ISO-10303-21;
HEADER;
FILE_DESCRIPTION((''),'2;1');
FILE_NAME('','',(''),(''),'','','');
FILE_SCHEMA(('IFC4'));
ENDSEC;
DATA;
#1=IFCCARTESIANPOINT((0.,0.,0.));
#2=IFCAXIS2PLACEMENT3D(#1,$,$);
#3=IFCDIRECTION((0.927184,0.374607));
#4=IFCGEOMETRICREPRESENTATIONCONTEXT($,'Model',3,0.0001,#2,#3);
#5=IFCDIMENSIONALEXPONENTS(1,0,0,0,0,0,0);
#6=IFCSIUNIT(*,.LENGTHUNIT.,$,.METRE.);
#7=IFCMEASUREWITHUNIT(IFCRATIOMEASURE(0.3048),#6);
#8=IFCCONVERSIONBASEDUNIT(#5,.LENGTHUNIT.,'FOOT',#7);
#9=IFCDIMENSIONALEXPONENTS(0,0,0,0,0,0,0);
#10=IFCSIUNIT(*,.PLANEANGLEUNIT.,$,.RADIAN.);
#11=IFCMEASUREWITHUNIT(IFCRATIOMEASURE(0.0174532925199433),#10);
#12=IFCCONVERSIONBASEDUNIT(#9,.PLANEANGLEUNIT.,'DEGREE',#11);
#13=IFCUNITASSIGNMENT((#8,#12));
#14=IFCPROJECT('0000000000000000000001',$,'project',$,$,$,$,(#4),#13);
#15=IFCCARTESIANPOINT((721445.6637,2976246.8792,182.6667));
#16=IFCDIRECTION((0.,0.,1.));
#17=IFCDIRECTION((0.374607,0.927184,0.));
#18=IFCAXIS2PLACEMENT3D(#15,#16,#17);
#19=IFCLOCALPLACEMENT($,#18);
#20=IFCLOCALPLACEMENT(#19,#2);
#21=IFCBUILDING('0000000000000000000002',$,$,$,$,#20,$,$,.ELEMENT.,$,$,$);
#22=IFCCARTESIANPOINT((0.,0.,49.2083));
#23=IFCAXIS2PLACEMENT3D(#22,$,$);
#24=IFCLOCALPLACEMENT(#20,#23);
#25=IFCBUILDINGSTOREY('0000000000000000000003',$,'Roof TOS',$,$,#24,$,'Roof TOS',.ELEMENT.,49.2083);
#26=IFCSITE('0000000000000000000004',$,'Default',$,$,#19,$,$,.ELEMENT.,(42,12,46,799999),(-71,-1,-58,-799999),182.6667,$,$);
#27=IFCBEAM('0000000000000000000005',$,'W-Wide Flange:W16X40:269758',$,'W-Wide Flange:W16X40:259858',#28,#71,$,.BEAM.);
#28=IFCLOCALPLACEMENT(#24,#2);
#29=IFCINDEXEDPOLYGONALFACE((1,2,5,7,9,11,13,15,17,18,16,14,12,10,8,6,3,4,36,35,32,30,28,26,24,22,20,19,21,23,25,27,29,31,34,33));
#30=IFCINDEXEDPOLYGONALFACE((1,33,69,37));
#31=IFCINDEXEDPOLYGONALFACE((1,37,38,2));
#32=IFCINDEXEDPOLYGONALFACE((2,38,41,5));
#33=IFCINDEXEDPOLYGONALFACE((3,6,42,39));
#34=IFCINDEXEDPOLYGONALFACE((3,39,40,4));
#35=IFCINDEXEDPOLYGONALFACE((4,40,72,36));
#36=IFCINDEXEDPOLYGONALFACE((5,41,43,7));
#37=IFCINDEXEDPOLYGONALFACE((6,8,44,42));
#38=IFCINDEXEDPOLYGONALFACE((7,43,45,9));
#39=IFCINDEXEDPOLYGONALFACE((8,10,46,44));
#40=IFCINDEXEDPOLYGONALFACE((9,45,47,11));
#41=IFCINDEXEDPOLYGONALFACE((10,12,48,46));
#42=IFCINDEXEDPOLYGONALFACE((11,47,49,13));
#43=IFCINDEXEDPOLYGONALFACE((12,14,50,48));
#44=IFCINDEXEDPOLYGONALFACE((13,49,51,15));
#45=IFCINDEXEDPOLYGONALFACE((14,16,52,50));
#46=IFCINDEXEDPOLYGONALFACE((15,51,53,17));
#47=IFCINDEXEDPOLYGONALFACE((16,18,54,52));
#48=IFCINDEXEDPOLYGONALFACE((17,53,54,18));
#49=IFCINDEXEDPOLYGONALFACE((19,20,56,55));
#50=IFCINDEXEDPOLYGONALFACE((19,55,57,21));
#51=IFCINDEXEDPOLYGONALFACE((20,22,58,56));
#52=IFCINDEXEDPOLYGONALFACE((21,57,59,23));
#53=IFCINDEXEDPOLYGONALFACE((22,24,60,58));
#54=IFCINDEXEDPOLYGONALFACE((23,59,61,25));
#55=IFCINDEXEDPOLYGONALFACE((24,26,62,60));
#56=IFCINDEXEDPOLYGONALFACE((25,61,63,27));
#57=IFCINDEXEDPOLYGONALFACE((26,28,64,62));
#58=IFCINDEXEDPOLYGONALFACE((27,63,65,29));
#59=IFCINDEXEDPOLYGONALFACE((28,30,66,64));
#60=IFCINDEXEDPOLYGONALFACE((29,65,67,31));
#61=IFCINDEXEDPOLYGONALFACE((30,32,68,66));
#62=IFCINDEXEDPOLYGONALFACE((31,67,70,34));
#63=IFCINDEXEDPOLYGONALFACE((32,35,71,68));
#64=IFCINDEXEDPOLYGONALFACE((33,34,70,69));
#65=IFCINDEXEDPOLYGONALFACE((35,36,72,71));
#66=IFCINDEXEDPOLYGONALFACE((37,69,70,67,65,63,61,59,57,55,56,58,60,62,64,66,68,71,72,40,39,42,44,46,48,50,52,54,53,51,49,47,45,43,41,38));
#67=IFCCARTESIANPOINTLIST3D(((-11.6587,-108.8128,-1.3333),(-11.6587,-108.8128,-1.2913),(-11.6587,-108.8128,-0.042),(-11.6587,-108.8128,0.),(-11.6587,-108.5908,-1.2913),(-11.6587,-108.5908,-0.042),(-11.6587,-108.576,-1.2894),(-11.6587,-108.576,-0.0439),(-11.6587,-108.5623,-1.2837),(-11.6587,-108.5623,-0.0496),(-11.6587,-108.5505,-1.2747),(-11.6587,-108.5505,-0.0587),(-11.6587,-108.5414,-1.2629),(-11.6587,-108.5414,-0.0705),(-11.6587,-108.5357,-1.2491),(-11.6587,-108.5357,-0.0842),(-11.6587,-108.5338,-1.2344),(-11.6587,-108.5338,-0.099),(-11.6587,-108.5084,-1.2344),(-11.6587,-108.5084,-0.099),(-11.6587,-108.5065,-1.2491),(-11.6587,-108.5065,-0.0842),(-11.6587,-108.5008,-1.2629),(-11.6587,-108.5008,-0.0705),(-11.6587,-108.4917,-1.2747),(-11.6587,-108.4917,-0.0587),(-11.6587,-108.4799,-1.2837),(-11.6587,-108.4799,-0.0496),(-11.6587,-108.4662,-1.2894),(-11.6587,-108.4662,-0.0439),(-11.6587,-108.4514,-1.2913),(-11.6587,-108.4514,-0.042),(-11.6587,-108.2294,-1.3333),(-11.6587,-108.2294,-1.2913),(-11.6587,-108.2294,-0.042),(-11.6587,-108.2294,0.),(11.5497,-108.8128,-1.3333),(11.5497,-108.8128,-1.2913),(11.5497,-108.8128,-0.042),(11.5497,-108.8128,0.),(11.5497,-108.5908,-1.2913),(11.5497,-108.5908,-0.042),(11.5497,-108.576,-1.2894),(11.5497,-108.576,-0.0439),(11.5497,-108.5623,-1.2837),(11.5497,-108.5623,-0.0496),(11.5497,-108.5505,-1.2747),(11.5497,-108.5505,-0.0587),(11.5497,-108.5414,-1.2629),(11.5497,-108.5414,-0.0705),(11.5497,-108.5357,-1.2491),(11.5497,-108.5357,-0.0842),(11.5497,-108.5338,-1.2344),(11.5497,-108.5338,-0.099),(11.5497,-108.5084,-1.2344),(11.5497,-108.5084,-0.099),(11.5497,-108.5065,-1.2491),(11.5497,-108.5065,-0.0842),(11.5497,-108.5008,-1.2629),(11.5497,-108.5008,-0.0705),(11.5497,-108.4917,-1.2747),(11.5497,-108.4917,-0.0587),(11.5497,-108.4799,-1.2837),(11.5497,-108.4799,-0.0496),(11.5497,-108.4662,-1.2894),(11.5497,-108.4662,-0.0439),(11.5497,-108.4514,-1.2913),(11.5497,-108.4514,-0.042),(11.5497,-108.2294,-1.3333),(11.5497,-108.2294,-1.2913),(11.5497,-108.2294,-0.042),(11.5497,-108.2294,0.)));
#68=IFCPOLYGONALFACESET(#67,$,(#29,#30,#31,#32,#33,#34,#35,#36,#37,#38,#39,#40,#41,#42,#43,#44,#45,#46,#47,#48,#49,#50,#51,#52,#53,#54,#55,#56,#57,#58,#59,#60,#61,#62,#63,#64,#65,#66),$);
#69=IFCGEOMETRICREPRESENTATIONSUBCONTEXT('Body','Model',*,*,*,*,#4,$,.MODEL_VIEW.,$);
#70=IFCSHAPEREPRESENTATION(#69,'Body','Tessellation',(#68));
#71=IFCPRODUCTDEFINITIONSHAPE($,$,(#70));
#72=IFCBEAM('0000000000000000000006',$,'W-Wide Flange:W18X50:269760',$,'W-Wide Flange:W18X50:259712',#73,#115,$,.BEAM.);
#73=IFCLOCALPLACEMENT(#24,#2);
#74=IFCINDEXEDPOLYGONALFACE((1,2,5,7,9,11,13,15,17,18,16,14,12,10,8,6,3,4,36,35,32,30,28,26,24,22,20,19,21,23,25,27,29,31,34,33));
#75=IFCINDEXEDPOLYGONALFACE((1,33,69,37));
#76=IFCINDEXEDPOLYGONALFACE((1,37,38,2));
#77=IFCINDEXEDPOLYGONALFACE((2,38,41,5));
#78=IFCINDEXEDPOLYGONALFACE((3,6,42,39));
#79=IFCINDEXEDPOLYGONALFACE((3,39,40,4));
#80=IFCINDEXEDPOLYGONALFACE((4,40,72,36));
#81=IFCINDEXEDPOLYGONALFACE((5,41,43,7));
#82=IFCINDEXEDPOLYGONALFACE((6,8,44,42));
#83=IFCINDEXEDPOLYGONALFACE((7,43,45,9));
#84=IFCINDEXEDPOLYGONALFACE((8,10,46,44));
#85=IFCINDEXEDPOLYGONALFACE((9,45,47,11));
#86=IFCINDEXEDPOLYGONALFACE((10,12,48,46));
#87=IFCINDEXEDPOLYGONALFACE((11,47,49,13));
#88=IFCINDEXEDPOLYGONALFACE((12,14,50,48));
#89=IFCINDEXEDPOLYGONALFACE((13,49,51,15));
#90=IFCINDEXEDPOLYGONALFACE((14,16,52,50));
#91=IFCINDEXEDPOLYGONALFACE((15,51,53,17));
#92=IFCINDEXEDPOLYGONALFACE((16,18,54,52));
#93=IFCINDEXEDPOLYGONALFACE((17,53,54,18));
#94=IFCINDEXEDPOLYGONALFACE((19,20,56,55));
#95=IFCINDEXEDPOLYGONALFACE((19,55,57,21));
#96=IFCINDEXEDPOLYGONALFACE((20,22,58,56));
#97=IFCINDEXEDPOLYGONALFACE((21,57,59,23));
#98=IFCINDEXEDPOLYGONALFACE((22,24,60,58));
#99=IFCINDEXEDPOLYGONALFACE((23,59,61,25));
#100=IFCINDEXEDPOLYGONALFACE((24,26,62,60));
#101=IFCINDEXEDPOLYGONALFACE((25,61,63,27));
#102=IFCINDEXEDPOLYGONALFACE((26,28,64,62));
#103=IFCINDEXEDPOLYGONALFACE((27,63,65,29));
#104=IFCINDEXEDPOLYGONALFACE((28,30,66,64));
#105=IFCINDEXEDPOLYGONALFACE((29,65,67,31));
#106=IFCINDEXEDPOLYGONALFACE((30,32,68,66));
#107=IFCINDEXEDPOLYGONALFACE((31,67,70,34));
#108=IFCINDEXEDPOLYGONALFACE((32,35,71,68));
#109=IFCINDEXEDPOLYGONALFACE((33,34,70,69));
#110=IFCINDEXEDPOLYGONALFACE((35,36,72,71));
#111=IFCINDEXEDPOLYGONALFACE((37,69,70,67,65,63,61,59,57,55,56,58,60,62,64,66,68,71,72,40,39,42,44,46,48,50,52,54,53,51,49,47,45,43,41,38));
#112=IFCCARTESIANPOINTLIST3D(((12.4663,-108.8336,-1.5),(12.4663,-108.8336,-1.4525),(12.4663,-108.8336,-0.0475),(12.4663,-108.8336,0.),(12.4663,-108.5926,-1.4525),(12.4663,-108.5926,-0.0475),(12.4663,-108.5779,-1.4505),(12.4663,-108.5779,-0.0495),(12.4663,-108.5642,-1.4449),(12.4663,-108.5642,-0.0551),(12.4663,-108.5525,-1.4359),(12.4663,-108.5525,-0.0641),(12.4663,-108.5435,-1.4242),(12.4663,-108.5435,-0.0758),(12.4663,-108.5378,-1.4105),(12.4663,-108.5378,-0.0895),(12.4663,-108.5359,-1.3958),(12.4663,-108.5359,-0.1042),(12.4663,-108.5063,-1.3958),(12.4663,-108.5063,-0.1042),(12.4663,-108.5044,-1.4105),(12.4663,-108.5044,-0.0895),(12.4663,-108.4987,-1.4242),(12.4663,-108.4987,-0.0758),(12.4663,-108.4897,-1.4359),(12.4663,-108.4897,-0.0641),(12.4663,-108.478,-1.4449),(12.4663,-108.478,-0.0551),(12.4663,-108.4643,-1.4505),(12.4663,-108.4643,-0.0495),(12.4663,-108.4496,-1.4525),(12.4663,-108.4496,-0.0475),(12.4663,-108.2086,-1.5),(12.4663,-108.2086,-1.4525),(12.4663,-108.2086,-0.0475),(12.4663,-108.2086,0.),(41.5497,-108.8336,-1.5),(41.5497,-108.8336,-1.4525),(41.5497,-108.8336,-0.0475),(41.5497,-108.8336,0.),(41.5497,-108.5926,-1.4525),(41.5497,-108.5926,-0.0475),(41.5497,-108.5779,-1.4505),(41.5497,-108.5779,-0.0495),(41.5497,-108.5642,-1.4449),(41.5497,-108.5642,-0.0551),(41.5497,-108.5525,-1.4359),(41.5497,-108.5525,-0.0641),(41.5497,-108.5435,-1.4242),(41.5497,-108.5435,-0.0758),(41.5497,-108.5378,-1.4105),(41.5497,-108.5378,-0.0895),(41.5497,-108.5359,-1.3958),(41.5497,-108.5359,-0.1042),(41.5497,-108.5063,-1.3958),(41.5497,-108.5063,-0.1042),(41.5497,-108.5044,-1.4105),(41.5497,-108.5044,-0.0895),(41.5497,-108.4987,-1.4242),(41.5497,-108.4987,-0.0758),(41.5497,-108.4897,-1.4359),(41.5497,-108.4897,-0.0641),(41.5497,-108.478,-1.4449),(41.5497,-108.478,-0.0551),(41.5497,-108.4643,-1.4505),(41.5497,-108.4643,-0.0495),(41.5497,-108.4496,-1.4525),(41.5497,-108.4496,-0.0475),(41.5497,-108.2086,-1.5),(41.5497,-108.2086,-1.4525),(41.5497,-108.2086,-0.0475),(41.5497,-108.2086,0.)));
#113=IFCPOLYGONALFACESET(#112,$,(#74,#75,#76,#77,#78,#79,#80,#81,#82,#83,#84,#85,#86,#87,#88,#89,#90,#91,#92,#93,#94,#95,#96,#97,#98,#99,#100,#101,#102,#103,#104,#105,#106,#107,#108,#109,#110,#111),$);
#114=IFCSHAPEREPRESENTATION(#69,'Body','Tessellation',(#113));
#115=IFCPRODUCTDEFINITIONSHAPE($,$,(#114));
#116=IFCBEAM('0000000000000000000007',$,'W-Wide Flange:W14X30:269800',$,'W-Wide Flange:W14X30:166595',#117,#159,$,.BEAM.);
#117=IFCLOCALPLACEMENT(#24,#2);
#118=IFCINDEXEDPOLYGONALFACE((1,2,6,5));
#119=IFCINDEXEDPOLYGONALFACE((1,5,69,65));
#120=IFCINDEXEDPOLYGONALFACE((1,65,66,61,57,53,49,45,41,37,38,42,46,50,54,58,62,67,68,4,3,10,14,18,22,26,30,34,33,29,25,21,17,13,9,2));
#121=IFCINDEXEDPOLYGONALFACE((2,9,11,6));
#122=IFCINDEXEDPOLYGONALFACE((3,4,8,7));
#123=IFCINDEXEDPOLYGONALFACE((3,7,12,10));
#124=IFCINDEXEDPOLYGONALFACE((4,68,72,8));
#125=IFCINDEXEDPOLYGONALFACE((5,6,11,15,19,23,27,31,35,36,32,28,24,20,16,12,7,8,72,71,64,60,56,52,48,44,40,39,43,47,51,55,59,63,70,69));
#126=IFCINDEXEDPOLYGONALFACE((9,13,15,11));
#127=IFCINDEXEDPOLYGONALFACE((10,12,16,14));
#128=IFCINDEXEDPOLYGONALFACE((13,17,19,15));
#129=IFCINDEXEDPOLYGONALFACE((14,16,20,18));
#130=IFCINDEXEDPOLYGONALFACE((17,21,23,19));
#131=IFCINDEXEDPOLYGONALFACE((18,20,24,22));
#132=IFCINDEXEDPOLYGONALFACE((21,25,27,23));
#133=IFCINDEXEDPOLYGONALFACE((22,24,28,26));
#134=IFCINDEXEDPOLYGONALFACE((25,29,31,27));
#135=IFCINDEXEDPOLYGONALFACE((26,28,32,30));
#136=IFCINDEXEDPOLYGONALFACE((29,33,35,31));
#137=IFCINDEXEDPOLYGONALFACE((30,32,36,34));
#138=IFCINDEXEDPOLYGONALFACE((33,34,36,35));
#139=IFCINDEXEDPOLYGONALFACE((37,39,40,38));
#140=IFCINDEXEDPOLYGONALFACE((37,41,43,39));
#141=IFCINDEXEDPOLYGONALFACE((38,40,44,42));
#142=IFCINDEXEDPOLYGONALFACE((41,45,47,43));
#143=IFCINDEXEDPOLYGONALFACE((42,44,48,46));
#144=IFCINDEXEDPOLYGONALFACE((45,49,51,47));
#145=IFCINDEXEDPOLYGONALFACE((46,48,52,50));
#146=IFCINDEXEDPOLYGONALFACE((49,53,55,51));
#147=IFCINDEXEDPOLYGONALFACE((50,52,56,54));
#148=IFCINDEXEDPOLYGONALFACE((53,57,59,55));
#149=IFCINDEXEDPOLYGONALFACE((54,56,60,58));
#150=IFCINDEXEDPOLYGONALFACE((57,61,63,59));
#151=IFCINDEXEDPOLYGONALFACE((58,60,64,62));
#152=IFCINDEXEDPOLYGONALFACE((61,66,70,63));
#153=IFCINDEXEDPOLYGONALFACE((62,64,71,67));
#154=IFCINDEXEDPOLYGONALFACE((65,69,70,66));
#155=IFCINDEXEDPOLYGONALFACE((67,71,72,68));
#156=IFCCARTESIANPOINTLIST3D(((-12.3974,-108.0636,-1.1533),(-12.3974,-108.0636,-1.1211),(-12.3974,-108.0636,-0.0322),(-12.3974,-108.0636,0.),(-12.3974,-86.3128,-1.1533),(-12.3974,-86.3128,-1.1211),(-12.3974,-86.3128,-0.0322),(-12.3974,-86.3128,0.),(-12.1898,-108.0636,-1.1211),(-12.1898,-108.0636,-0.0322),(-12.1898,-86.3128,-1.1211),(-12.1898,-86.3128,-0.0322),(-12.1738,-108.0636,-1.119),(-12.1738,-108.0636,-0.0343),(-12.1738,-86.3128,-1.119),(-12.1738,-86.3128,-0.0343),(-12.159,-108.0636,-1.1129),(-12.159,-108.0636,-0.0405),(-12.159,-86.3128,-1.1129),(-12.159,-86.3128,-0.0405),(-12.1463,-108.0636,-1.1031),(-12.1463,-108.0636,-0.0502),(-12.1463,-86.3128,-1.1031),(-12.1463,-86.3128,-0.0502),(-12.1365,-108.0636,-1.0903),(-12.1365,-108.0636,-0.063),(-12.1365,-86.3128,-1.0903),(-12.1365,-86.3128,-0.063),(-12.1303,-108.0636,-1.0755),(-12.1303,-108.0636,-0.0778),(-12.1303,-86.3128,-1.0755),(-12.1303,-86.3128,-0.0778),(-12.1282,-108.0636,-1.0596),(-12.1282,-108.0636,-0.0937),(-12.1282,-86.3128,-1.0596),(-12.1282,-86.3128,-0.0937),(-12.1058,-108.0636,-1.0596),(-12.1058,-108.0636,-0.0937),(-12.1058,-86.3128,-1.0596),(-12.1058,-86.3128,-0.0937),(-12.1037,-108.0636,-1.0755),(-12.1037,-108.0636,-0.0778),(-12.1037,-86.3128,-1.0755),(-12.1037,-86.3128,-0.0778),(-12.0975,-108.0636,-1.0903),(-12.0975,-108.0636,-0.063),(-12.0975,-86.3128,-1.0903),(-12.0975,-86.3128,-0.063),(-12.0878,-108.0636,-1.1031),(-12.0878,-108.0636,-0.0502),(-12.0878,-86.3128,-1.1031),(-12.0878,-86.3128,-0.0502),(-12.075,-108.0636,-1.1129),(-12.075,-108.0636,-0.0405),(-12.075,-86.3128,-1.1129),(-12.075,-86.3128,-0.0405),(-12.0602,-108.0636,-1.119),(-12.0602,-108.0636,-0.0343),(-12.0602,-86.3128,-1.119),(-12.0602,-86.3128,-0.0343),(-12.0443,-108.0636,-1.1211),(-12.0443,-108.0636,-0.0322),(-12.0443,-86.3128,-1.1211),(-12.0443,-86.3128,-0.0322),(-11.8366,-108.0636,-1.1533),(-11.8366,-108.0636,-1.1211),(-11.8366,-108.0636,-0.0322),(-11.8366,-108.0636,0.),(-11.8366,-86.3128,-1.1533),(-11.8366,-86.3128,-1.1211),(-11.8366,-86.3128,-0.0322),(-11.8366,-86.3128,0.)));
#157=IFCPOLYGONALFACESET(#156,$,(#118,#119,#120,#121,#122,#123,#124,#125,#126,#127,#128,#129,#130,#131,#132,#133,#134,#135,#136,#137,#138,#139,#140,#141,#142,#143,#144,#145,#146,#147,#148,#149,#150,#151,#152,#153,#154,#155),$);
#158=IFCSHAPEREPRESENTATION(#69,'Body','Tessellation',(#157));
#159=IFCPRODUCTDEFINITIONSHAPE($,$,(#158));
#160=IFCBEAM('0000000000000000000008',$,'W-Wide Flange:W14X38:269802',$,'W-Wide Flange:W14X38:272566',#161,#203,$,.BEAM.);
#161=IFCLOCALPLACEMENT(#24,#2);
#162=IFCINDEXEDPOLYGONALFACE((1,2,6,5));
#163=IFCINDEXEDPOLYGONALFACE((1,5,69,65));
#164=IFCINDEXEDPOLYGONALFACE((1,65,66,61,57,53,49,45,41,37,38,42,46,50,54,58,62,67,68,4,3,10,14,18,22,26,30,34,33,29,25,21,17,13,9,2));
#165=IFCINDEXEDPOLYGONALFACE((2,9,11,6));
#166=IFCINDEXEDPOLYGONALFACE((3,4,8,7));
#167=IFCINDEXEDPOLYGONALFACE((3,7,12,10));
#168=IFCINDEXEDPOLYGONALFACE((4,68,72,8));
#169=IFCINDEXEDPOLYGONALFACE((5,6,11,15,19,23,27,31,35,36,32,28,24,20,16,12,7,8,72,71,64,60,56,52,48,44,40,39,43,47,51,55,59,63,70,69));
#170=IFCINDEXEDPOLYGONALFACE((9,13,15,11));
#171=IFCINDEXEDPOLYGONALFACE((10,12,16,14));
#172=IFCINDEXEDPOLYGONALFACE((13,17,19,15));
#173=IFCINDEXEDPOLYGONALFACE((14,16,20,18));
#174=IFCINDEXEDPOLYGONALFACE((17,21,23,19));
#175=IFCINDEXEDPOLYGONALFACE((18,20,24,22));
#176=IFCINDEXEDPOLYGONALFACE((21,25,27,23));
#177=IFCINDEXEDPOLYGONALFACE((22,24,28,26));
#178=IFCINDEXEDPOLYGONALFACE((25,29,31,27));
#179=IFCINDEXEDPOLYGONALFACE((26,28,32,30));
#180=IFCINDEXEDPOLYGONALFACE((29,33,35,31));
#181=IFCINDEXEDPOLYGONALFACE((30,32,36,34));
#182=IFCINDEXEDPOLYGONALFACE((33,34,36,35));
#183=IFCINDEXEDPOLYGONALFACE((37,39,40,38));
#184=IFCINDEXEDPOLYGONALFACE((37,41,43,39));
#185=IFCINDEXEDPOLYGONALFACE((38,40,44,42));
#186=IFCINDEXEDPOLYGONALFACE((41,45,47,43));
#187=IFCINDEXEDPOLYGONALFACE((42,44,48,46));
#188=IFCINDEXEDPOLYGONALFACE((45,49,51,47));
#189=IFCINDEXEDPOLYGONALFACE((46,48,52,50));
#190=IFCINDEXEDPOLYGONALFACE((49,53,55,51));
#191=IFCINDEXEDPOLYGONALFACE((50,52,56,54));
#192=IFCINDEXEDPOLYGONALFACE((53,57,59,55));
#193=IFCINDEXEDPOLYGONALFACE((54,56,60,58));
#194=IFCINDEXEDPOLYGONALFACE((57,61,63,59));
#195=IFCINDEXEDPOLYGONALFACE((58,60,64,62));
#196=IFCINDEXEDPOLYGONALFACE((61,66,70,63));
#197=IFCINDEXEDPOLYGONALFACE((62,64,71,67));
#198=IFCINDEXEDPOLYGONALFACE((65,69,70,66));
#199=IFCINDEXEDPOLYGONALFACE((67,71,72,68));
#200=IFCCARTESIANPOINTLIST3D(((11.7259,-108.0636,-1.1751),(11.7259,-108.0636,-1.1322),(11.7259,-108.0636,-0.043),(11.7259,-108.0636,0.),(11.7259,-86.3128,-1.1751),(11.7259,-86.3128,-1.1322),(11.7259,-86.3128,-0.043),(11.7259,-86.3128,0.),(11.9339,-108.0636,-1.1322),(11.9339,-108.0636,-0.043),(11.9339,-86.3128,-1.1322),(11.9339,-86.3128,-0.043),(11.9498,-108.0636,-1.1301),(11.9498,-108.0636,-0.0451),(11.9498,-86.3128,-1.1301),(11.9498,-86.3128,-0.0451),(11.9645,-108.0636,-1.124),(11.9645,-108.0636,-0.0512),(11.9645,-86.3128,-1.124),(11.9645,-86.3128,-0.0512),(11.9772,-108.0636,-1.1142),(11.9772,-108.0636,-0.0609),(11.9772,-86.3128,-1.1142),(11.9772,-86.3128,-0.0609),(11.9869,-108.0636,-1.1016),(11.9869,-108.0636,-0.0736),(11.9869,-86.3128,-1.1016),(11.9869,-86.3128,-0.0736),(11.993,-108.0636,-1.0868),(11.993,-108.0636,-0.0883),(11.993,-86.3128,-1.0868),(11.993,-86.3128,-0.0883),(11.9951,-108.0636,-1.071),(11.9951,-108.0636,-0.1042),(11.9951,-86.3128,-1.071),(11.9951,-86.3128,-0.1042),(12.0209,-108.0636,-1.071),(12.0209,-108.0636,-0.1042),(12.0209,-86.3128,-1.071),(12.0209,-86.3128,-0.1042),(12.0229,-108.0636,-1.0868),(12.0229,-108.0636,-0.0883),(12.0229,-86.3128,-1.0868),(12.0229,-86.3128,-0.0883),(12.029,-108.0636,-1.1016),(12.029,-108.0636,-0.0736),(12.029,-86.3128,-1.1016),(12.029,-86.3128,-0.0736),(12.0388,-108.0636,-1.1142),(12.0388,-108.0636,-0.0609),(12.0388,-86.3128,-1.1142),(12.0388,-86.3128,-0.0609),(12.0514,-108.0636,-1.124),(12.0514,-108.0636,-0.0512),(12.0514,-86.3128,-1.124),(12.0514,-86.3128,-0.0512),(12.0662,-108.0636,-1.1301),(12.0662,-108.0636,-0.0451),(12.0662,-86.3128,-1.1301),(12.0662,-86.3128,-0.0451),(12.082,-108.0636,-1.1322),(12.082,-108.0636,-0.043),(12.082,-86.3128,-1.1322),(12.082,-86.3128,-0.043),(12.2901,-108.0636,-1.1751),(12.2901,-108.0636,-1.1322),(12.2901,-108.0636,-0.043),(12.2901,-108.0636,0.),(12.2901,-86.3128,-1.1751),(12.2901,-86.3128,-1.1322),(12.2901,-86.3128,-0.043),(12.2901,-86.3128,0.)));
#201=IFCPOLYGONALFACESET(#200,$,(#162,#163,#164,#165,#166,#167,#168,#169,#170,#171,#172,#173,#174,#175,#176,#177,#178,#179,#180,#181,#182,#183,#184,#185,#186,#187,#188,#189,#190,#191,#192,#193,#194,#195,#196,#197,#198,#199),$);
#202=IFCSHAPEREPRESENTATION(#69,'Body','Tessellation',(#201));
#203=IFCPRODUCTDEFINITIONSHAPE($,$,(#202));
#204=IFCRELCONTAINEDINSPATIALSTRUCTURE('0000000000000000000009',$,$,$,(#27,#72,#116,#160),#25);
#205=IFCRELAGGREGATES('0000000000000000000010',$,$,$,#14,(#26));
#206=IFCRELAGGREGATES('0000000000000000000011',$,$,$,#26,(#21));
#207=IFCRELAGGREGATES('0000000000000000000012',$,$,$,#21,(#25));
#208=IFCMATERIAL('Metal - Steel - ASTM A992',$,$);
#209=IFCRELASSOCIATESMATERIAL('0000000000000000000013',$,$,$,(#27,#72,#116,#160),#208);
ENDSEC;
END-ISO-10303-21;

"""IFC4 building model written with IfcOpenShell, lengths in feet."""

from ifc_helpers import new_model, entity, si_unit, converted_unit, direction, frame, frame_2d, origin, place, context, subcontext, project, spatial, i_section, extrude, material, element, save


model = new_model("IFC4")

# Units and contexts
model_context = context("Model", 3, precision=0.0001, world=origin(), true_north=direction((0.927184, 0.374607)))
body_context = subcontext(model_context, "Body", "Model", "MODEL_VIEW")
ifc_project = project(units=[converted_unit("LENGTHUNIT", "FOOT", entity("IfcRatioMeasure", 0.3048), si_unit("LENGTHUNIT", "METRE"), dimensions=[1, 0, 0, 0, 0, 0, 0]), converted_unit("PLANEANGLEUNIT", "DEGREE", entity("IfcRatioMeasure", 0.0174532925199433), si_unit("PLANEANGLEUNIT", "RADIAN"), dimensions=[0, 0, 0, 0, 0, 0, 0])], contexts=[model_context])

# Site, building, storey
site_placement = place(None, frame((721445.6637, 2976246.8792, 182.6667), z_axis=(0.0, 0.0, 1.0), x_axis=(0.374607, 0.927184, 0.0)))
site = spatial("IfcSite", under=ifc_project, at=site_placement, Name="Default", CompositionType="ELEMENT", RefLatitude=(42, 12, 46, 799999), RefLongitude=(-71, -1, -58, -799999), RefElevation=182.6667)
building_placement = place(site_placement, origin())
building = spatial("IfcBuilding", under=site, at=building_placement, CompositionType="ELEMENT")
storey_placement = place(building_placement, frame((0.0, 0.0, 49.2083)))
storey = spatial("IfcBuildingStorey", under=building, at=storey_placement, Name="Roof TOS", LongName="Roof TOS", CompositionType="ELEMENT", Elevation=49.2083)

# Beams
ifc_material = material(Name="Metal - Steel - ASTM A992")
beam_1_placement = place(storey_placement, frame((-12.117, -108.5211, 0.0)))
element("IfcBeam", 1, at=beam_1_placement, inside=storey, material=ifc_material, Name="W-Wide Flange:W16X40:269758", ObjectType="W-Wide Flange:W16X40:259858", PredefinedType="BEAM", context=body_context, shape_type="SweptSolid", body=[
    extrude(i_section(OverallWidth=0.5833, OverallDepth=1.3333, WebThickness=0.0254, FlangeThickness=0.042, FilletRadius=0.057, at=frame_2d((0.0, 0.0), x_axis=(0.0, 1.0))), frame((0.4583, 0.0, -0.6667), z_axis=(1.0, 0.0, 0.0), x_axis=(0.0, 0.0, -1.0)), (0.0, 0.0, 1.0), 23.2083),
])
beam_2_placement = place(storey_placement, frame((12.008, -108.5211, 0.0)))
element("IfcBeam", 2, at=beam_2_placement, inside=storey, material=ifc_material, Name="W-Wide Flange:W18X50:269760", ObjectType="W-Wide Flange:W18X50:259712", PredefinedType="BEAM", context=body_context, shape_type="SweptSolid", body=[
    extrude(i_section(OverallWidth=0.625, OverallDepth=1.5, WebThickness=0.0296, FlangeThickness=0.0475, FilletRadius=0.0566, at=frame_2d((0.0, 0.0), x_axis=(0.0, 1.0))), frame((0.4583, 0.0, -0.75), z_axis=(1.0, 0.0, 0.0), x_axis=(0.0, 0.0, -1.0)), (0.0, 0.0, 1.0), 29.0833),
])
beam_3_placement = place(storey_placement, frame((-12.117, -85.8544, 0.0), z_axis=(0.0, 0.0, 1.0), x_axis=(0.0, -1.0, 0.0)))
element("IfcBeam", 3, at=beam_3_placement, inside=storey, material=ifc_material, Name="W-Wide Flange:W14X30:269800", ObjectType="W-Wide Flange:W14X30:166595", PredefinedType="BEAM", context=body_context, shape_type="SweptSolid", body=[
    extrude(i_section(OverallWidth=0.5609, OverallDepth=1.1533, WebThickness=0.0225, FlangeThickness=0.0322, FilletRadius=0.0615, at=frame_2d((0.0, 0.0), x_axis=(0.0, 1.0))), frame((0.4583, 0.0, -0.5767), z_axis=(1.0, 0.0, 0.0), x_axis=(0.0, 0.0, -1.0)), (0.0, 0.0, 1.0), 21.7508),
])
beam_4_placement = place(storey_placement, frame((12.008, -108.5211, 0.0), z_axis=(0.0, 0.0, 1.0), x_axis=(0.0, 1.0, 0.0)))
element("IfcBeam", 4, at=beam_4_placement, inside=storey, material=ifc_material, Name="W-Wide Flange:W14X38:269802", ObjectType="W-Wide Flange:W14X38:272566", PredefinedType="BEAM", context=body_context, shape_type="SweptSolid", body=[
    extrude(i_section(OverallWidth=0.5641, OverallDepth=1.1751, WebThickness=0.0257, FlangeThickness=0.043, FilletRadius=0.0612, at=frame_2d((0.0, 0.0), x_axis=(0.0, 1.0))), frame((0.4575, 0.0, -0.5876), z_axis=(1.0, 0.0, 0.0), x_axis=(0.0, 0.0, -1.0)), (0.0, 0.0, 1.0), 21.7508),
])

save(model, "model.ifc")
